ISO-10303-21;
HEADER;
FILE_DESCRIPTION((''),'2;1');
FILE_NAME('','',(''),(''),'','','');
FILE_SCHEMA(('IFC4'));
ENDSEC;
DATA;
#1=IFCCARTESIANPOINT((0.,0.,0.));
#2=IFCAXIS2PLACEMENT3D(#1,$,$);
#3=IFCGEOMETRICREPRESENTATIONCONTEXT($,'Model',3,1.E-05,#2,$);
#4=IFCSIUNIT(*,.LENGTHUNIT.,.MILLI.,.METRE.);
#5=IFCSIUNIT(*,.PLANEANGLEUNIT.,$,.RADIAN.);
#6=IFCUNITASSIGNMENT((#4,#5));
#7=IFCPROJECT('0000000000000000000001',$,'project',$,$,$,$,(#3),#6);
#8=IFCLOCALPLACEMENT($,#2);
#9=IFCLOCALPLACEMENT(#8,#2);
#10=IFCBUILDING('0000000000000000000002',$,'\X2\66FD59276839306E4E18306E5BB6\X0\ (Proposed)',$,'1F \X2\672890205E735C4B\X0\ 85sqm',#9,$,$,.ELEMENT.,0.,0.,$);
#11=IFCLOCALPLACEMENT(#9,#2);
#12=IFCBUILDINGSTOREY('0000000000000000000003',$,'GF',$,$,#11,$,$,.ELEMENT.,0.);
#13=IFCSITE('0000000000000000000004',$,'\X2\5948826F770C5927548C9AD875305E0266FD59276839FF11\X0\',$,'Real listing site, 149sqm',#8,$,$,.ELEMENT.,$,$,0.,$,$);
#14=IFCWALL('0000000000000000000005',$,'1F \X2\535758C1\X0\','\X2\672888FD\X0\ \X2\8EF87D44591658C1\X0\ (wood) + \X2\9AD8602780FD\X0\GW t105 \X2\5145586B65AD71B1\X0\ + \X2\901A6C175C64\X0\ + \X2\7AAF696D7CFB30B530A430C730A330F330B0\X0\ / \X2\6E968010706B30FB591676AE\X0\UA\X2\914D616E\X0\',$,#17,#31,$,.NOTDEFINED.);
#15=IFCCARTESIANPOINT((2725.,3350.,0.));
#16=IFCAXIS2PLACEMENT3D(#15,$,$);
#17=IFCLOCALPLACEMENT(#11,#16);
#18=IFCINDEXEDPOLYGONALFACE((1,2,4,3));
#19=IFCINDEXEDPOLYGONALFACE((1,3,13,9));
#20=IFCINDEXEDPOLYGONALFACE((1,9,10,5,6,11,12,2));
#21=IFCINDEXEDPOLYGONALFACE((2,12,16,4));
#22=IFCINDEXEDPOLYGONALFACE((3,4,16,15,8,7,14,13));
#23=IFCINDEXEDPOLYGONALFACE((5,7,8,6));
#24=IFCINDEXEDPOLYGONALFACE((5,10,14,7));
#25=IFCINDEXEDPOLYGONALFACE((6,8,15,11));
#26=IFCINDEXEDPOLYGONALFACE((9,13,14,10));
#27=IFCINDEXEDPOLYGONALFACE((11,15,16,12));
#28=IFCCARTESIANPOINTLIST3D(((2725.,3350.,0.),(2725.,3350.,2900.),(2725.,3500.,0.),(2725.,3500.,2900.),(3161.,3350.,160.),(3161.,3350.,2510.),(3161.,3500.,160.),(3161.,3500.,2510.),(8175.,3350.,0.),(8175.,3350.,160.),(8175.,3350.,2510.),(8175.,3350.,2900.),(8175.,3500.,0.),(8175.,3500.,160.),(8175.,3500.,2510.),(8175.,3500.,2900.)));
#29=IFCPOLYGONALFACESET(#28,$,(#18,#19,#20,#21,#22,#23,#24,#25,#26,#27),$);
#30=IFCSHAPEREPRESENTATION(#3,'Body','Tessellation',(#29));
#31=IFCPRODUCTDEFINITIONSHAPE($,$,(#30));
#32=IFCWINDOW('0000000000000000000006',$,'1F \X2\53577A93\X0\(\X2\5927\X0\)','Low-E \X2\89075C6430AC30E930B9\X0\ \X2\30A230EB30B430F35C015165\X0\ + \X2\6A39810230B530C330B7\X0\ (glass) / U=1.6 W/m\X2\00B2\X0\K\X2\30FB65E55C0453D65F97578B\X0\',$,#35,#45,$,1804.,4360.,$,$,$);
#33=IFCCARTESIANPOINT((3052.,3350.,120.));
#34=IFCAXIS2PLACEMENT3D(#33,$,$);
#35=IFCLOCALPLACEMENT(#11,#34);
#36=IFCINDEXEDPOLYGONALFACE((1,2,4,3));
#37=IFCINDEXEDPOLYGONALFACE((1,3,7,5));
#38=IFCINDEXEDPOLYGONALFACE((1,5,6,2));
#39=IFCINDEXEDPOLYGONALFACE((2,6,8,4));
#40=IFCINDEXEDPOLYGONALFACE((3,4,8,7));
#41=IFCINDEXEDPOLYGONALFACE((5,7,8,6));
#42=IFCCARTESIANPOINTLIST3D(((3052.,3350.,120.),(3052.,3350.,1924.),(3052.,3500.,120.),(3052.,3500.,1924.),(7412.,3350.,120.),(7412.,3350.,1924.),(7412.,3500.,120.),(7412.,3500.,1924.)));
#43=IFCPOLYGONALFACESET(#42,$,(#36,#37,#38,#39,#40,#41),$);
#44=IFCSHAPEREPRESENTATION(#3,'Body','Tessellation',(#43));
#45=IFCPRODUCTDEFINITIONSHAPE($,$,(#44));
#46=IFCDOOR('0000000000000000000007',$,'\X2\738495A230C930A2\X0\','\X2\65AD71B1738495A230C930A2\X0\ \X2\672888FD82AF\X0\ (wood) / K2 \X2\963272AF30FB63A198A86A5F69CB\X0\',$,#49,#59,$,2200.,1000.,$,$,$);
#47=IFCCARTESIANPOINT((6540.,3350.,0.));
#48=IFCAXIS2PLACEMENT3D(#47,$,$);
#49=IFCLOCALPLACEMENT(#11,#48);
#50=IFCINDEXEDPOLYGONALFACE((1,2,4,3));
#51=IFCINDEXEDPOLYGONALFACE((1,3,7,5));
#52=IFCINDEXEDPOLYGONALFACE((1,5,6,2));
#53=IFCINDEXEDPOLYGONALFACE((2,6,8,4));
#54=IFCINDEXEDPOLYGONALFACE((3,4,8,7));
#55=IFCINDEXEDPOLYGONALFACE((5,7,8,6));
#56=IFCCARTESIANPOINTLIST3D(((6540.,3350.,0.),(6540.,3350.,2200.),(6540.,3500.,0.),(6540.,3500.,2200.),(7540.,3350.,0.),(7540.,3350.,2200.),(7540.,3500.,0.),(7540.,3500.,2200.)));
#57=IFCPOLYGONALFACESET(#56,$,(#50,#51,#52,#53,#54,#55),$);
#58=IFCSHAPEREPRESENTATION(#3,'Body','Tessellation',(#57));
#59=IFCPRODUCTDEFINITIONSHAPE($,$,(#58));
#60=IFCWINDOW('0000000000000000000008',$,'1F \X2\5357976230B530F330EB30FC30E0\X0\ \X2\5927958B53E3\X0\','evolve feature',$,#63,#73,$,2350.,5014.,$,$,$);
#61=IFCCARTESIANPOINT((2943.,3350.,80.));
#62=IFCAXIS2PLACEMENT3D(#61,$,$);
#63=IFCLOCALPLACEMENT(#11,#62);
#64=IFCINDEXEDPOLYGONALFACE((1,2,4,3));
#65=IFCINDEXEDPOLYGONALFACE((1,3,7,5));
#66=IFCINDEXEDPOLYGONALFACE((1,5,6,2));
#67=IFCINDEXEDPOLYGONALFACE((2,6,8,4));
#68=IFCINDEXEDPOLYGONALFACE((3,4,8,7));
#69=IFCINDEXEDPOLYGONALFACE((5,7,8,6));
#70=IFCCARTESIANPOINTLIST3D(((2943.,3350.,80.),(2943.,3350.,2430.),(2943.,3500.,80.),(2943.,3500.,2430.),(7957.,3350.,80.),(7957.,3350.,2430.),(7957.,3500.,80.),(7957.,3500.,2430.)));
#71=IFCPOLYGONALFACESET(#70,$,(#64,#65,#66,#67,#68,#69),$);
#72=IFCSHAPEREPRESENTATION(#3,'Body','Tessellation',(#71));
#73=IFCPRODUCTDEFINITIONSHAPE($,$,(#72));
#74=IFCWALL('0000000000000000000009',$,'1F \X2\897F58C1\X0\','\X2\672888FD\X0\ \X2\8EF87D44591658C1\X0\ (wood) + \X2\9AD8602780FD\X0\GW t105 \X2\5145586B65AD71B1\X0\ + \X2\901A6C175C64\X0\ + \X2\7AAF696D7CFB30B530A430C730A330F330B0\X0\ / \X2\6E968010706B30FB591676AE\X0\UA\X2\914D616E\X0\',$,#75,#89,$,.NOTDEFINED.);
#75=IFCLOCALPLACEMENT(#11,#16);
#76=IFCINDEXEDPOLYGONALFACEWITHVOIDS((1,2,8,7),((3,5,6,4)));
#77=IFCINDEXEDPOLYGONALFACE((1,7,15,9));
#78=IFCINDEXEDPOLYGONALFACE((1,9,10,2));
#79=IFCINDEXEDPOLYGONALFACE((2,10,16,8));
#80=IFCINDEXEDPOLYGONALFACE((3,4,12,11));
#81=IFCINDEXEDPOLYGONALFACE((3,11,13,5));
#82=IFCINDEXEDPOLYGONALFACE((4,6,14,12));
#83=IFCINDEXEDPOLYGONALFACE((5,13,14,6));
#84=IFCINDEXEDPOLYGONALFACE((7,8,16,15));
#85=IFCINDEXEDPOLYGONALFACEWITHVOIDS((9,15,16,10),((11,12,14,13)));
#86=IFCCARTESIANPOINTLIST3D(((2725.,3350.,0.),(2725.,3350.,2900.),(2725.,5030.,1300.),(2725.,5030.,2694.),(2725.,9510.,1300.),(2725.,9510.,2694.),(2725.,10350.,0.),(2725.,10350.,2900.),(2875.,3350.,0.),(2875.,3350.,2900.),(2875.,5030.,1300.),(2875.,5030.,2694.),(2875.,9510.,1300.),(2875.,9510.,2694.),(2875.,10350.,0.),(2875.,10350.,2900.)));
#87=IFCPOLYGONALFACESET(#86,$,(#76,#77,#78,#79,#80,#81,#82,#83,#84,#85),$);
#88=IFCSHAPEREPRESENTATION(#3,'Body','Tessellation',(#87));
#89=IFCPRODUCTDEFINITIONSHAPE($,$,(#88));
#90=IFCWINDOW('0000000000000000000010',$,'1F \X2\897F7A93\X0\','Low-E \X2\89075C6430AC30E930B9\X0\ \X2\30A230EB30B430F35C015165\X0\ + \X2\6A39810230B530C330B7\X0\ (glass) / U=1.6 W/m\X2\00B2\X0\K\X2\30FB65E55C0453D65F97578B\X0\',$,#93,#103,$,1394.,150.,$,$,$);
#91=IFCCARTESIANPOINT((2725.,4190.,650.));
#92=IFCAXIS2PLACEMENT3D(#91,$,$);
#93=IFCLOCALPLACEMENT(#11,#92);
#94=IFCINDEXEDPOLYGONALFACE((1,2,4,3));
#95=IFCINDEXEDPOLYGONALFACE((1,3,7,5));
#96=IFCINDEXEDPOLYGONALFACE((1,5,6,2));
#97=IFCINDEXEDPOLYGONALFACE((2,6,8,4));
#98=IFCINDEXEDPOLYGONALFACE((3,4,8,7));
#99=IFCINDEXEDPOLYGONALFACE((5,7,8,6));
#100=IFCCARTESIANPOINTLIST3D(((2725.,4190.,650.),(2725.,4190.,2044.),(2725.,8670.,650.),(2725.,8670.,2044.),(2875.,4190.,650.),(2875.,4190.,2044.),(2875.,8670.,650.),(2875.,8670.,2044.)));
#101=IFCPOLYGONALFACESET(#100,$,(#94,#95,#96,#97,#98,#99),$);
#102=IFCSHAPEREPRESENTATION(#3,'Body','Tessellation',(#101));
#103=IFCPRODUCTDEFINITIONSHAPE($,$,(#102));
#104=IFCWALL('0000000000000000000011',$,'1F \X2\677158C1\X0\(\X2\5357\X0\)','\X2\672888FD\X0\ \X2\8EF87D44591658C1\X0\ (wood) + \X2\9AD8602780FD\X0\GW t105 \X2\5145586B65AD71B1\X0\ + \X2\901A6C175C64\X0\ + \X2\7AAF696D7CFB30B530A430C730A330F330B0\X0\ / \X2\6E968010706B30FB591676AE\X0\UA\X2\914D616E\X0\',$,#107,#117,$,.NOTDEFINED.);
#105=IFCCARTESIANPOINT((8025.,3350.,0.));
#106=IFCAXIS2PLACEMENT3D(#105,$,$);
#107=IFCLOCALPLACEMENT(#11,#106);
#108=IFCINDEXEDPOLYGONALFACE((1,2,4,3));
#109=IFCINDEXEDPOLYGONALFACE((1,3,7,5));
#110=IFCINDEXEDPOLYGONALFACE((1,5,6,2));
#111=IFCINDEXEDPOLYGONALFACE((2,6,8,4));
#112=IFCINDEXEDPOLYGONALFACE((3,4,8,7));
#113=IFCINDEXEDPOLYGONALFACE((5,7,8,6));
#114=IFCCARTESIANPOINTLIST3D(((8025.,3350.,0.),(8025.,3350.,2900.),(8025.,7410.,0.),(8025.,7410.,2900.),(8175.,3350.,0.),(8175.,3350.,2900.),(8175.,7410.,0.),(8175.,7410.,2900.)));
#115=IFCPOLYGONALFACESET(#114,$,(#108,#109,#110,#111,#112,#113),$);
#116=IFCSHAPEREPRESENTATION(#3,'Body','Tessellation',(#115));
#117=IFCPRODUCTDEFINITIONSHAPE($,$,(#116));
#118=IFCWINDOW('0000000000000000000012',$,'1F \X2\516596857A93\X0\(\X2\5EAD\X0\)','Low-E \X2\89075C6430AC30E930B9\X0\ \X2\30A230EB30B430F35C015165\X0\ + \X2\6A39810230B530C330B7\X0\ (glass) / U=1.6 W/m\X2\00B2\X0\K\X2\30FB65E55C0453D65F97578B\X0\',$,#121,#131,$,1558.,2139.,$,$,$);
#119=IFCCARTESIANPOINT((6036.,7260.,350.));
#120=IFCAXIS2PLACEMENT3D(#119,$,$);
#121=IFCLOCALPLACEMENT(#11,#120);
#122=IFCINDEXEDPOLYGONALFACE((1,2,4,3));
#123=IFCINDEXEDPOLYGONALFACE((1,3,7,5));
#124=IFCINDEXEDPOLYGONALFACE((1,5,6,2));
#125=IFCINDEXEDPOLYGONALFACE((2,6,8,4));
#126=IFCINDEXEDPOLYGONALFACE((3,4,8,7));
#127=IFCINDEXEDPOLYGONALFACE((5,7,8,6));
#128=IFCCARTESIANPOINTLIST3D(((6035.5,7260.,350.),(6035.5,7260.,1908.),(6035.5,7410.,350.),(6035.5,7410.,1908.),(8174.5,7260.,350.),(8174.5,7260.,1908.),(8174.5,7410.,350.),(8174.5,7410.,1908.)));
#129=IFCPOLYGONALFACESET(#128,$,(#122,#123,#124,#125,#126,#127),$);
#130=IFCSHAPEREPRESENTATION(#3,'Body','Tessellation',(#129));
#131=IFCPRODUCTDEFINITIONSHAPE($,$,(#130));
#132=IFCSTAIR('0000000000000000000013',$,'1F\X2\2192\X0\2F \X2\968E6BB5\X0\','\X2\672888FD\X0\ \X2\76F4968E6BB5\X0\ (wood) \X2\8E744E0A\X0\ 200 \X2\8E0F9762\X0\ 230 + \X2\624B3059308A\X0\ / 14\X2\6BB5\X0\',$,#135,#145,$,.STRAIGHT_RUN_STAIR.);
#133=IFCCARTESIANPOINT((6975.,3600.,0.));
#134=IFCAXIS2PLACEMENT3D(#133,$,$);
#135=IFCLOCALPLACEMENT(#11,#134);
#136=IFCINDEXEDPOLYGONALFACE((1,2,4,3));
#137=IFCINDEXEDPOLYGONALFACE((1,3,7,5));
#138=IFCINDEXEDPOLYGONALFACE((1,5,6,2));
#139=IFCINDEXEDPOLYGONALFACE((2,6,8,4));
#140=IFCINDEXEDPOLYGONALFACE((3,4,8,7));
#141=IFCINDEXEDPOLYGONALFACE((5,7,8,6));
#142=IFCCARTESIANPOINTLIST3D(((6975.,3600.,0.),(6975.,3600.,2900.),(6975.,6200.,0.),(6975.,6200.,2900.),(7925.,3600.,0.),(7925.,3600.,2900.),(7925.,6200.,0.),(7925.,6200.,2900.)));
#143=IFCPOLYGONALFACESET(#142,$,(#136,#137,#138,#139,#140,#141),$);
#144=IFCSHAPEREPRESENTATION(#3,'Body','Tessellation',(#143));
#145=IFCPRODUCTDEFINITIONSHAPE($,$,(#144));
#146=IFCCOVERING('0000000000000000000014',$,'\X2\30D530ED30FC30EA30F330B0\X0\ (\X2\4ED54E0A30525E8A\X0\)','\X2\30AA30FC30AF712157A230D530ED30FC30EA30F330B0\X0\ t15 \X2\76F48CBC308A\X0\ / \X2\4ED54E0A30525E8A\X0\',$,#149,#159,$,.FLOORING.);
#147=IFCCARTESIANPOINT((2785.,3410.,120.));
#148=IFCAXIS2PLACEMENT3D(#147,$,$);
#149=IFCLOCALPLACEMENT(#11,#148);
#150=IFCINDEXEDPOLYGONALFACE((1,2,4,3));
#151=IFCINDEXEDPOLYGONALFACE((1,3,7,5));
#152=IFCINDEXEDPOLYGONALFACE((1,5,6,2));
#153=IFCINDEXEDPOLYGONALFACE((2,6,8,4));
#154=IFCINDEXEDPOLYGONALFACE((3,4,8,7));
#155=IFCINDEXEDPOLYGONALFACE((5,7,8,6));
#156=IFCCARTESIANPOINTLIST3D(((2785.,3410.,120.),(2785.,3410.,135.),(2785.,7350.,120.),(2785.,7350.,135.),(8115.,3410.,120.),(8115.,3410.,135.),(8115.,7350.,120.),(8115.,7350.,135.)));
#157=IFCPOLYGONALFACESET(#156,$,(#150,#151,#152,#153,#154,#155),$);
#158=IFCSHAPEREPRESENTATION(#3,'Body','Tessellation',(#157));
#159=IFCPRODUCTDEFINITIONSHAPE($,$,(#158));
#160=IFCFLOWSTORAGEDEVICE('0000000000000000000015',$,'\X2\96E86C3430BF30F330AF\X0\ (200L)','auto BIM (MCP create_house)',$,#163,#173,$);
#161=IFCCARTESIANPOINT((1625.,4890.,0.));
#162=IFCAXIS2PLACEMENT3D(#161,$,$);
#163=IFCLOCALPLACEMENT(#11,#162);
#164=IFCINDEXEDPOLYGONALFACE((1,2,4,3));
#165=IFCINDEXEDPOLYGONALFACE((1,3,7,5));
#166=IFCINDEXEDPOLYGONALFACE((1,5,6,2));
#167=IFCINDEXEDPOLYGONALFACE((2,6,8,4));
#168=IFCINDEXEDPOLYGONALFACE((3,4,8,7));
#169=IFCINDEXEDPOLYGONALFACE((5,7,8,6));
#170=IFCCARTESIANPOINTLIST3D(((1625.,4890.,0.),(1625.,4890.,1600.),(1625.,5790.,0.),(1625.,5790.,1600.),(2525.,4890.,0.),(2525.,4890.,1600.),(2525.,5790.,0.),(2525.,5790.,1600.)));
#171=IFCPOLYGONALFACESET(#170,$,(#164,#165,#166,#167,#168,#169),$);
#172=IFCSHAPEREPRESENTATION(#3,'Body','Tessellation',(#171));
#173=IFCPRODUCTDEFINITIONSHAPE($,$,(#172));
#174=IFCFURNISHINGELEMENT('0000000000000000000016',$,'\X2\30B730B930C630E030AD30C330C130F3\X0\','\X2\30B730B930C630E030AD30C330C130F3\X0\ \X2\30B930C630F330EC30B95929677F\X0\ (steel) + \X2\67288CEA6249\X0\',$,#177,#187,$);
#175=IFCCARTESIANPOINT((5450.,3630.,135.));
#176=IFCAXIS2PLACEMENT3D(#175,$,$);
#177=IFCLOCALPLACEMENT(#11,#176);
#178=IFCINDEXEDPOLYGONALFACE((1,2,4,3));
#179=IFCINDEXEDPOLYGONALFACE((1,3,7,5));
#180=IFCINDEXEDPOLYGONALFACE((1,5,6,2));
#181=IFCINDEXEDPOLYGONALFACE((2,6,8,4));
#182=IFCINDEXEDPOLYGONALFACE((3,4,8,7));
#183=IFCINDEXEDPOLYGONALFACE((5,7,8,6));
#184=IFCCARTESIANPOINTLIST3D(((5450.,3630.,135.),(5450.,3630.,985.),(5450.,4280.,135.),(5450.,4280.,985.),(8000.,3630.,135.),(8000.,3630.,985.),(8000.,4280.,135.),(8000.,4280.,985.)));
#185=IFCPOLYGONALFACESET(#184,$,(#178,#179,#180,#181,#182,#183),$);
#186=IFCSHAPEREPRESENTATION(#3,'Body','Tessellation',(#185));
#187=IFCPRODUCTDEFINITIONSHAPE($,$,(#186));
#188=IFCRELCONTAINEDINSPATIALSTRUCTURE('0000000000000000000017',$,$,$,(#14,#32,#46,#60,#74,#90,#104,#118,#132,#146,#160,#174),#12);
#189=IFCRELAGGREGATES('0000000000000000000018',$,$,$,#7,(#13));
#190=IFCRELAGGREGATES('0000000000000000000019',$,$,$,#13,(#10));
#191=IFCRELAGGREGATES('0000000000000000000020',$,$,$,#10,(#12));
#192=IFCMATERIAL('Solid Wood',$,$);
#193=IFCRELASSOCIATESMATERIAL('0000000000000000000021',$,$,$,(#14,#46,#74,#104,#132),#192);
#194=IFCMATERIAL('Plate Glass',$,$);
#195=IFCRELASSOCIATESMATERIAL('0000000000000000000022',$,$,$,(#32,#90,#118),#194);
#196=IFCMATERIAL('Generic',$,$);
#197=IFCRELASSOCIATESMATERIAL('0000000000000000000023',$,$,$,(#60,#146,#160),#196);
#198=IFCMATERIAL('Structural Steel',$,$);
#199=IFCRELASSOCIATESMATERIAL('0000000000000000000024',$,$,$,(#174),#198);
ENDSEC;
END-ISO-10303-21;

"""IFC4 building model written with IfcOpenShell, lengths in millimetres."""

from ifc_helpers import new_model, si_unit, frame, frame_2d, origin, place, context, project, spatial, rectangle, extrude, material, element, fill, save


model = new_model("IFC4")

# Units and contexts
model_context = context("Model", 3, precision=1e-05, world=origin())
ifc_project = project(units=[si_unit("LENGTHUNIT", "METRE", prefix="MILLI"), si_unit("PLANEANGLEUNIT", "RADIAN")], contexts=[model_context])

# Site, building, storey
site_placement = place(None, origin())
site = spatial("IfcSite", under=ifc_project, at=site_placement, Name="奈良県大和高田市曽大根１", ObjectType="Real listing site, 149sqm", CompositionType="ELEMENT", RefElevation=0.0)
building_placement = place(site_placement, origin())
building = spatial("IfcBuilding", under=site, at=building_placement, Name="曽大根の丘の家 (Proposed)", ObjectType="1F 木造平屋 85sqm", CompositionType="ELEMENT", ElevationOfRefHeight=0.0, ElevationOfTerrain=0.0)
storey_placement = place(building_placement, origin())
storey = spatial("IfcBuildingStorey", under=building, at=storey_placement, Name="GF", CompositionType="ELEMENT", Elevation=0.0)

# Shared definitions
ifc_material_1 = material(Name="Solid Wood")
ifc_material_2 = material(Name="Generic")

# Wall, openings, windows, door
wall_1_placement = place(storey_placement, frame((2725.0, 3350.0, 0.0)))
wall_1 = element("IfcWall", 1, at=wall_1_placement, inside=storey, material=ifc_material_1, Name="1F 南壁", Description="木製 軸組外壁 (wood) + 高性能GW t105 充填断熱 + 通気層 + 窯業系サイディング / 準耐火・外皮UA配慮", PredefinedType="NOTDEFINED", context=model_context, shape_type="SweptSolid", body=[
    extrude(rectangle(XDim=5450.0, YDim=150.0, at=frame_2d((2725.0, 75.0))), frame((2725.0, 3350.0, 0.0)), (0.0, 0.0, 1.0), 2900.0),
])
opening_1_placement = place(storey_placement, frame((3052.0, 3350.0, 120.0)))
opening_1 = element("IfcOpeningElement", 2, at=opening_1_placement, cuts=wall_1, PredefinedType="NOTDEFINED", context=model_context, shape_type="SweptSolid", body=[
    extrude(rectangle(XDim=4360.0, YDim=150.0, at=frame_2d((2180.0, 75.0))), frame((3052.0, 3350.0, 120.0)), (0.0, 0.0, 1.0), 1804.0),
])
opening_2_placement = place(storey_placement, frame((6540.0, 3350.0, 0.0)))
opening_2 = element("IfcOpeningElement", 3, at=opening_2_placement, cuts=wall_1, PredefinedType="NOTDEFINED", context=model_context, shape_type="SweptSolid", body=[
    extrude(rectangle(XDim=1000.0, YDim=150.0, at=frame_2d((500.0, 75.0))), frame((6540.0, 3350.0, 0.0)), (0.0, 0.0, 1.0), 2200.0),
])
opening_3_placement = place(storey_placement, frame((2943.0, 3350.0, 80.0)))
opening_3 = element("IfcOpeningElement", 4, at=opening_3_placement, cuts=wall_1, PredefinedType="NOTDEFINED", context=model_context, shape_type="SweptSolid", body=[
    extrude(rectangle(XDim=5014.0, YDim=150.0, at=frame_2d((2507.0, 75.0))), frame((2943.0, 3350.0, 80.0)), (0.0, 0.0, 1.0), 2350.0),
])
ifc_material_3 = material(Name="Plate Glass")
window_1_placement = place(storey_placement, frame((3052.0, 3350.0, 120.0)))
window_1 = element("IfcWindow", 5, at=window_1_placement, inside=storey, material=ifc_material_3, Name="1F 南窓(大)", Description="Low-E 複層ガラス アルゴン封入 + 樹脂サッシ (glass) / U=1.6 W/m²K・日射取得型", OverallHeight=1804.0, OverallWidth=4360.0, context=model_context, shape_type="SweptSolid", body=[
    extrude(rectangle(XDim=4360.0, YDim=150.0, at=frame_2d((2180.0, 75.0))), frame((3052.0, 3350.0, 120.0)), (0.0, 0.0, 1.0), 1804.0),
])
fill(opening_1, window_1)
door_1_placement = place(storey_placement, frame((6540.0, 3350.0, 0.0)))
door_1 = element("IfcDoor", 6, at=door_1_placement, inside=storey, material=ifc_material_1, Name="玄関ドア", Description="断熱玄関ドア 木製芯 (wood) / K2 防犯・採風機構", OverallHeight=2200.0, OverallWidth=1000.0, context=model_context, shape_type="SweptSolid", body=[
    extrude(rectangle(XDim=1000.0, YDim=150.0, at=frame_2d((500.0, 75.0))), frame((6540.0, 3350.0, 0.0)), (0.0, 0.0, 1.0), 2200.0),
])
fill(opening_2, door_1)
window_2_placement = place(storey_placement, frame((2943.0, 3350.0, 80.0)))
window_2 = element("IfcWindow", 7, at=window_2_placement, inside=storey, material=ifc_material_2, Name="1F 南面サンルーム 大開口", Description="evolve feature", OverallHeight=2350.0, OverallWidth=5014.0, context=model_context, shape_type="SweptSolid", body=[
    extrude(rectangle(XDim=5014.0, YDim=150.0, at=frame_2d((2507.0, 75.0))), frame((2943.0, 3350.0, 80.0)), (0.0, 0.0, 1.0), 2350.0),
])
fill(opening_3, window_2)

# Walls, openings, windows
wall_2_placement = place(storey_placement, frame((2725.0, 3350.0, 0.0)))
wall_2 = element("IfcWall", 8, at=wall_2_placement, inside=storey, material=ifc_material_1, Name="1F 西壁", Description="木製 軸組外壁 (wood) + 高性能GW t105 充填断熱 + 通気層 + 窯業系サイディング / 準耐火・外皮UA配慮", PredefinedType="NOTDEFINED", context=model_context, shape_type="SweptSolid", body=[
    extrude(rectangle(XDim=150.0, YDim=7000.0, at=frame_2d((75.0, 3500.0))), frame((2725.0, 3350.0, 0.0)), (0.0, 0.0, 1.0), 2900.0),
])
opening_4_placement = place(storey_placement, frame((2725.0, 4190.0, 650.0)))
opening_4 = element("IfcOpeningElement", 9, at=opening_4_placement, cuts=wall_2, PredefinedType="NOTDEFINED", context=model_context, shape_type="SweptSolid", body=[
    extrude(rectangle(XDim=150.0, YDim=4480.0, at=frame_2d((75.0, 2240.0))), frame((2725.0, 4190.0, 650.0)), (0.0, 0.0, 1.0), 1394.0),
])
window_3_placement = place(storey_placement, frame((2725.0, 4190.0, 650.0)))
window_3 = element("IfcWindow", 10, at=window_3_placement, inside=storey, material=ifc_material_3, Name="1F 西窓", Description="Low-E 複層ガラス アルゴン封入 + 樹脂サッシ (glass) / U=1.6 W/m²K・日射取得型", OverallHeight=1394.0, OverallWidth=150.0, context=model_context, shape_type="SweptSolid", body=[
    extrude(rectangle(XDim=150.0, YDim=4480.0, at=frame_2d((75.0, 2240.0))), frame((2725.0, 4190.0, 650.0)), (0.0, 0.0, 1.0), 1394.0),
])
fill(opening_4, window_3)
wall_3_placement = place(storey_placement, frame((8025.0, 3350.0, 0.0)))
wall_3 = element("IfcWall", 11, at=wall_3_placement, inside=storey, material=ifc_material_1, Name="1F 東壁(南)", Description="木製 軸組外壁 (wood) + 高性能GW t105 充填断熱 + 通気層 + 窯業系サイディング / 準耐火・外皮UA配慮", PredefinedType="NOTDEFINED", context=model_context, shape_type="SweptSolid", body=[
    extrude(rectangle(XDim=150.0, YDim=4060.0, at=frame_2d((75.0, 2030.0))), frame((8025.0, 3350.0, 0.0)), (0.0, 0.0, 1.0), 2900.0),
])
opening_5_placement = place(storey_placement, frame((6036.0, 7260.0, 350.0)))
opening_5 = element("IfcOpeningElement", 12, at=opening_5_placement, cuts=wall_3, PredefinedType="NOTDEFINED", context=model_context, shape_type="SweptSolid", body=[
    extrude(rectangle(XDim=2139.0, YDim=150.0, at=frame_2d((1069.0, 75.0))), frame((6036.0, 7260.0, 350.0)), (0.0, 0.0, 1.0), 1558.0),
])
window_4_placement = place(storey_placement, frame((6036.0, 7260.0, 350.0)))
window_4 = element("IfcWindow", 13, at=window_4_placement, inside=storey, material=ifc_material_3, Name="1F 入隅窓(庭)", Description="Low-E 複層ガラス アルゴン封入 + 樹脂サッシ (glass) / U=1.6 W/m²K・日射取得型", OverallHeight=1558.0, OverallWidth=2139.0, context=model_context, shape_type="SweptSolid", body=[
    extrude(rectangle(XDim=2139.0, YDim=150.0, at=frame_2d((1069.0, 75.0))), frame((6036.0, 7260.0, 350.0)), (0.0, 0.0, 1.0), 1558.0),
])
fill(opening_5, window_4)

# Stair
stair_placement = place(storey_placement, frame((6975.0, 3600.0, 0.0)))
element("IfcStair", 14, at=stair_placement, inside=storey, material=ifc_material_1, Name="1F→2F 階段", Description="木製 直階段 (wood) 蹴上 200 踏面 230 + 手すり / 14段", PredefinedType="STRAIGHT_RUN_STAIR", context=model_context, shape_type="SweptSolid", body=[
    extrude(rectangle(XDim=950.0, YDim=2600.0, at=frame_2d((475.0, 1300.0))), frame((6975.0, 3600.0, 0.0)), (0.0, 0.0, 1.0), 2900.0),
])

# Covering
covering_placement = place(storey_placement, frame((2785.0, 3410.0, 120.0)))
element("IfcCovering", 15, at=covering_placement, inside=storey, material=ifc_material_2, Name="フローリング (仕上げ床)", Description="オーク無垢フローリング t15 直貼り / 仕上げ床", PredefinedType="FLOORING", context=model_context, shape_type="SweptSolid", body=[
    extrude(rectangle(XDim=5330.0, YDim=3940.0, at=frame_2d((2665.0, 1970.0))), frame((2785.0, 3410.0, 120.0)), (0.0, 0.0, 1.0), 15.0),
])

# Flow storage device
flow_storage_device_placement = place(storey_placement, frame((1625.0, 4890.0, 0.0)))
element("IfcFlowStorageDevice", 16, at=flow_storage_device_placement, inside=storey, material=ifc_material_2, Name="雨水タンク (200L)", Description="auto BIM (MCP create_house)", context=model_context, shape_type="SweptSolid", body=[
    extrude(rectangle(XDim=900.0, YDim=900.0, at=frame_2d((450.0, 450.0))), frame((1625.0, 4890.0, 0.0)), (0.0, 0.0, 1.0), 1600.0),
])

# Furnishing element
ifc_material_4 = material(Name="Structural Steel")
furnishing_placement = place(storey_placement, frame((5450.0, 3630.0, 135.0)))
element("IfcFurnishingElement", 17, at=furnishing_placement, inside=storey, material=ifc_material_4, Name="システムキッチン", Description="システムキッチン ステンレス天板 (steel) + 木質扉", context=model_context, shape_type="SweptSolid", body=[
    extrude(rectangle(XDim=2550.0, YDim=650.0, at=frame_2d((1275.0, 325.0))), frame((5450.0, 3630.0, 135.0)), (0.0, 0.0, 1.0), 850.0),
])

save(model, "model.ifc")
